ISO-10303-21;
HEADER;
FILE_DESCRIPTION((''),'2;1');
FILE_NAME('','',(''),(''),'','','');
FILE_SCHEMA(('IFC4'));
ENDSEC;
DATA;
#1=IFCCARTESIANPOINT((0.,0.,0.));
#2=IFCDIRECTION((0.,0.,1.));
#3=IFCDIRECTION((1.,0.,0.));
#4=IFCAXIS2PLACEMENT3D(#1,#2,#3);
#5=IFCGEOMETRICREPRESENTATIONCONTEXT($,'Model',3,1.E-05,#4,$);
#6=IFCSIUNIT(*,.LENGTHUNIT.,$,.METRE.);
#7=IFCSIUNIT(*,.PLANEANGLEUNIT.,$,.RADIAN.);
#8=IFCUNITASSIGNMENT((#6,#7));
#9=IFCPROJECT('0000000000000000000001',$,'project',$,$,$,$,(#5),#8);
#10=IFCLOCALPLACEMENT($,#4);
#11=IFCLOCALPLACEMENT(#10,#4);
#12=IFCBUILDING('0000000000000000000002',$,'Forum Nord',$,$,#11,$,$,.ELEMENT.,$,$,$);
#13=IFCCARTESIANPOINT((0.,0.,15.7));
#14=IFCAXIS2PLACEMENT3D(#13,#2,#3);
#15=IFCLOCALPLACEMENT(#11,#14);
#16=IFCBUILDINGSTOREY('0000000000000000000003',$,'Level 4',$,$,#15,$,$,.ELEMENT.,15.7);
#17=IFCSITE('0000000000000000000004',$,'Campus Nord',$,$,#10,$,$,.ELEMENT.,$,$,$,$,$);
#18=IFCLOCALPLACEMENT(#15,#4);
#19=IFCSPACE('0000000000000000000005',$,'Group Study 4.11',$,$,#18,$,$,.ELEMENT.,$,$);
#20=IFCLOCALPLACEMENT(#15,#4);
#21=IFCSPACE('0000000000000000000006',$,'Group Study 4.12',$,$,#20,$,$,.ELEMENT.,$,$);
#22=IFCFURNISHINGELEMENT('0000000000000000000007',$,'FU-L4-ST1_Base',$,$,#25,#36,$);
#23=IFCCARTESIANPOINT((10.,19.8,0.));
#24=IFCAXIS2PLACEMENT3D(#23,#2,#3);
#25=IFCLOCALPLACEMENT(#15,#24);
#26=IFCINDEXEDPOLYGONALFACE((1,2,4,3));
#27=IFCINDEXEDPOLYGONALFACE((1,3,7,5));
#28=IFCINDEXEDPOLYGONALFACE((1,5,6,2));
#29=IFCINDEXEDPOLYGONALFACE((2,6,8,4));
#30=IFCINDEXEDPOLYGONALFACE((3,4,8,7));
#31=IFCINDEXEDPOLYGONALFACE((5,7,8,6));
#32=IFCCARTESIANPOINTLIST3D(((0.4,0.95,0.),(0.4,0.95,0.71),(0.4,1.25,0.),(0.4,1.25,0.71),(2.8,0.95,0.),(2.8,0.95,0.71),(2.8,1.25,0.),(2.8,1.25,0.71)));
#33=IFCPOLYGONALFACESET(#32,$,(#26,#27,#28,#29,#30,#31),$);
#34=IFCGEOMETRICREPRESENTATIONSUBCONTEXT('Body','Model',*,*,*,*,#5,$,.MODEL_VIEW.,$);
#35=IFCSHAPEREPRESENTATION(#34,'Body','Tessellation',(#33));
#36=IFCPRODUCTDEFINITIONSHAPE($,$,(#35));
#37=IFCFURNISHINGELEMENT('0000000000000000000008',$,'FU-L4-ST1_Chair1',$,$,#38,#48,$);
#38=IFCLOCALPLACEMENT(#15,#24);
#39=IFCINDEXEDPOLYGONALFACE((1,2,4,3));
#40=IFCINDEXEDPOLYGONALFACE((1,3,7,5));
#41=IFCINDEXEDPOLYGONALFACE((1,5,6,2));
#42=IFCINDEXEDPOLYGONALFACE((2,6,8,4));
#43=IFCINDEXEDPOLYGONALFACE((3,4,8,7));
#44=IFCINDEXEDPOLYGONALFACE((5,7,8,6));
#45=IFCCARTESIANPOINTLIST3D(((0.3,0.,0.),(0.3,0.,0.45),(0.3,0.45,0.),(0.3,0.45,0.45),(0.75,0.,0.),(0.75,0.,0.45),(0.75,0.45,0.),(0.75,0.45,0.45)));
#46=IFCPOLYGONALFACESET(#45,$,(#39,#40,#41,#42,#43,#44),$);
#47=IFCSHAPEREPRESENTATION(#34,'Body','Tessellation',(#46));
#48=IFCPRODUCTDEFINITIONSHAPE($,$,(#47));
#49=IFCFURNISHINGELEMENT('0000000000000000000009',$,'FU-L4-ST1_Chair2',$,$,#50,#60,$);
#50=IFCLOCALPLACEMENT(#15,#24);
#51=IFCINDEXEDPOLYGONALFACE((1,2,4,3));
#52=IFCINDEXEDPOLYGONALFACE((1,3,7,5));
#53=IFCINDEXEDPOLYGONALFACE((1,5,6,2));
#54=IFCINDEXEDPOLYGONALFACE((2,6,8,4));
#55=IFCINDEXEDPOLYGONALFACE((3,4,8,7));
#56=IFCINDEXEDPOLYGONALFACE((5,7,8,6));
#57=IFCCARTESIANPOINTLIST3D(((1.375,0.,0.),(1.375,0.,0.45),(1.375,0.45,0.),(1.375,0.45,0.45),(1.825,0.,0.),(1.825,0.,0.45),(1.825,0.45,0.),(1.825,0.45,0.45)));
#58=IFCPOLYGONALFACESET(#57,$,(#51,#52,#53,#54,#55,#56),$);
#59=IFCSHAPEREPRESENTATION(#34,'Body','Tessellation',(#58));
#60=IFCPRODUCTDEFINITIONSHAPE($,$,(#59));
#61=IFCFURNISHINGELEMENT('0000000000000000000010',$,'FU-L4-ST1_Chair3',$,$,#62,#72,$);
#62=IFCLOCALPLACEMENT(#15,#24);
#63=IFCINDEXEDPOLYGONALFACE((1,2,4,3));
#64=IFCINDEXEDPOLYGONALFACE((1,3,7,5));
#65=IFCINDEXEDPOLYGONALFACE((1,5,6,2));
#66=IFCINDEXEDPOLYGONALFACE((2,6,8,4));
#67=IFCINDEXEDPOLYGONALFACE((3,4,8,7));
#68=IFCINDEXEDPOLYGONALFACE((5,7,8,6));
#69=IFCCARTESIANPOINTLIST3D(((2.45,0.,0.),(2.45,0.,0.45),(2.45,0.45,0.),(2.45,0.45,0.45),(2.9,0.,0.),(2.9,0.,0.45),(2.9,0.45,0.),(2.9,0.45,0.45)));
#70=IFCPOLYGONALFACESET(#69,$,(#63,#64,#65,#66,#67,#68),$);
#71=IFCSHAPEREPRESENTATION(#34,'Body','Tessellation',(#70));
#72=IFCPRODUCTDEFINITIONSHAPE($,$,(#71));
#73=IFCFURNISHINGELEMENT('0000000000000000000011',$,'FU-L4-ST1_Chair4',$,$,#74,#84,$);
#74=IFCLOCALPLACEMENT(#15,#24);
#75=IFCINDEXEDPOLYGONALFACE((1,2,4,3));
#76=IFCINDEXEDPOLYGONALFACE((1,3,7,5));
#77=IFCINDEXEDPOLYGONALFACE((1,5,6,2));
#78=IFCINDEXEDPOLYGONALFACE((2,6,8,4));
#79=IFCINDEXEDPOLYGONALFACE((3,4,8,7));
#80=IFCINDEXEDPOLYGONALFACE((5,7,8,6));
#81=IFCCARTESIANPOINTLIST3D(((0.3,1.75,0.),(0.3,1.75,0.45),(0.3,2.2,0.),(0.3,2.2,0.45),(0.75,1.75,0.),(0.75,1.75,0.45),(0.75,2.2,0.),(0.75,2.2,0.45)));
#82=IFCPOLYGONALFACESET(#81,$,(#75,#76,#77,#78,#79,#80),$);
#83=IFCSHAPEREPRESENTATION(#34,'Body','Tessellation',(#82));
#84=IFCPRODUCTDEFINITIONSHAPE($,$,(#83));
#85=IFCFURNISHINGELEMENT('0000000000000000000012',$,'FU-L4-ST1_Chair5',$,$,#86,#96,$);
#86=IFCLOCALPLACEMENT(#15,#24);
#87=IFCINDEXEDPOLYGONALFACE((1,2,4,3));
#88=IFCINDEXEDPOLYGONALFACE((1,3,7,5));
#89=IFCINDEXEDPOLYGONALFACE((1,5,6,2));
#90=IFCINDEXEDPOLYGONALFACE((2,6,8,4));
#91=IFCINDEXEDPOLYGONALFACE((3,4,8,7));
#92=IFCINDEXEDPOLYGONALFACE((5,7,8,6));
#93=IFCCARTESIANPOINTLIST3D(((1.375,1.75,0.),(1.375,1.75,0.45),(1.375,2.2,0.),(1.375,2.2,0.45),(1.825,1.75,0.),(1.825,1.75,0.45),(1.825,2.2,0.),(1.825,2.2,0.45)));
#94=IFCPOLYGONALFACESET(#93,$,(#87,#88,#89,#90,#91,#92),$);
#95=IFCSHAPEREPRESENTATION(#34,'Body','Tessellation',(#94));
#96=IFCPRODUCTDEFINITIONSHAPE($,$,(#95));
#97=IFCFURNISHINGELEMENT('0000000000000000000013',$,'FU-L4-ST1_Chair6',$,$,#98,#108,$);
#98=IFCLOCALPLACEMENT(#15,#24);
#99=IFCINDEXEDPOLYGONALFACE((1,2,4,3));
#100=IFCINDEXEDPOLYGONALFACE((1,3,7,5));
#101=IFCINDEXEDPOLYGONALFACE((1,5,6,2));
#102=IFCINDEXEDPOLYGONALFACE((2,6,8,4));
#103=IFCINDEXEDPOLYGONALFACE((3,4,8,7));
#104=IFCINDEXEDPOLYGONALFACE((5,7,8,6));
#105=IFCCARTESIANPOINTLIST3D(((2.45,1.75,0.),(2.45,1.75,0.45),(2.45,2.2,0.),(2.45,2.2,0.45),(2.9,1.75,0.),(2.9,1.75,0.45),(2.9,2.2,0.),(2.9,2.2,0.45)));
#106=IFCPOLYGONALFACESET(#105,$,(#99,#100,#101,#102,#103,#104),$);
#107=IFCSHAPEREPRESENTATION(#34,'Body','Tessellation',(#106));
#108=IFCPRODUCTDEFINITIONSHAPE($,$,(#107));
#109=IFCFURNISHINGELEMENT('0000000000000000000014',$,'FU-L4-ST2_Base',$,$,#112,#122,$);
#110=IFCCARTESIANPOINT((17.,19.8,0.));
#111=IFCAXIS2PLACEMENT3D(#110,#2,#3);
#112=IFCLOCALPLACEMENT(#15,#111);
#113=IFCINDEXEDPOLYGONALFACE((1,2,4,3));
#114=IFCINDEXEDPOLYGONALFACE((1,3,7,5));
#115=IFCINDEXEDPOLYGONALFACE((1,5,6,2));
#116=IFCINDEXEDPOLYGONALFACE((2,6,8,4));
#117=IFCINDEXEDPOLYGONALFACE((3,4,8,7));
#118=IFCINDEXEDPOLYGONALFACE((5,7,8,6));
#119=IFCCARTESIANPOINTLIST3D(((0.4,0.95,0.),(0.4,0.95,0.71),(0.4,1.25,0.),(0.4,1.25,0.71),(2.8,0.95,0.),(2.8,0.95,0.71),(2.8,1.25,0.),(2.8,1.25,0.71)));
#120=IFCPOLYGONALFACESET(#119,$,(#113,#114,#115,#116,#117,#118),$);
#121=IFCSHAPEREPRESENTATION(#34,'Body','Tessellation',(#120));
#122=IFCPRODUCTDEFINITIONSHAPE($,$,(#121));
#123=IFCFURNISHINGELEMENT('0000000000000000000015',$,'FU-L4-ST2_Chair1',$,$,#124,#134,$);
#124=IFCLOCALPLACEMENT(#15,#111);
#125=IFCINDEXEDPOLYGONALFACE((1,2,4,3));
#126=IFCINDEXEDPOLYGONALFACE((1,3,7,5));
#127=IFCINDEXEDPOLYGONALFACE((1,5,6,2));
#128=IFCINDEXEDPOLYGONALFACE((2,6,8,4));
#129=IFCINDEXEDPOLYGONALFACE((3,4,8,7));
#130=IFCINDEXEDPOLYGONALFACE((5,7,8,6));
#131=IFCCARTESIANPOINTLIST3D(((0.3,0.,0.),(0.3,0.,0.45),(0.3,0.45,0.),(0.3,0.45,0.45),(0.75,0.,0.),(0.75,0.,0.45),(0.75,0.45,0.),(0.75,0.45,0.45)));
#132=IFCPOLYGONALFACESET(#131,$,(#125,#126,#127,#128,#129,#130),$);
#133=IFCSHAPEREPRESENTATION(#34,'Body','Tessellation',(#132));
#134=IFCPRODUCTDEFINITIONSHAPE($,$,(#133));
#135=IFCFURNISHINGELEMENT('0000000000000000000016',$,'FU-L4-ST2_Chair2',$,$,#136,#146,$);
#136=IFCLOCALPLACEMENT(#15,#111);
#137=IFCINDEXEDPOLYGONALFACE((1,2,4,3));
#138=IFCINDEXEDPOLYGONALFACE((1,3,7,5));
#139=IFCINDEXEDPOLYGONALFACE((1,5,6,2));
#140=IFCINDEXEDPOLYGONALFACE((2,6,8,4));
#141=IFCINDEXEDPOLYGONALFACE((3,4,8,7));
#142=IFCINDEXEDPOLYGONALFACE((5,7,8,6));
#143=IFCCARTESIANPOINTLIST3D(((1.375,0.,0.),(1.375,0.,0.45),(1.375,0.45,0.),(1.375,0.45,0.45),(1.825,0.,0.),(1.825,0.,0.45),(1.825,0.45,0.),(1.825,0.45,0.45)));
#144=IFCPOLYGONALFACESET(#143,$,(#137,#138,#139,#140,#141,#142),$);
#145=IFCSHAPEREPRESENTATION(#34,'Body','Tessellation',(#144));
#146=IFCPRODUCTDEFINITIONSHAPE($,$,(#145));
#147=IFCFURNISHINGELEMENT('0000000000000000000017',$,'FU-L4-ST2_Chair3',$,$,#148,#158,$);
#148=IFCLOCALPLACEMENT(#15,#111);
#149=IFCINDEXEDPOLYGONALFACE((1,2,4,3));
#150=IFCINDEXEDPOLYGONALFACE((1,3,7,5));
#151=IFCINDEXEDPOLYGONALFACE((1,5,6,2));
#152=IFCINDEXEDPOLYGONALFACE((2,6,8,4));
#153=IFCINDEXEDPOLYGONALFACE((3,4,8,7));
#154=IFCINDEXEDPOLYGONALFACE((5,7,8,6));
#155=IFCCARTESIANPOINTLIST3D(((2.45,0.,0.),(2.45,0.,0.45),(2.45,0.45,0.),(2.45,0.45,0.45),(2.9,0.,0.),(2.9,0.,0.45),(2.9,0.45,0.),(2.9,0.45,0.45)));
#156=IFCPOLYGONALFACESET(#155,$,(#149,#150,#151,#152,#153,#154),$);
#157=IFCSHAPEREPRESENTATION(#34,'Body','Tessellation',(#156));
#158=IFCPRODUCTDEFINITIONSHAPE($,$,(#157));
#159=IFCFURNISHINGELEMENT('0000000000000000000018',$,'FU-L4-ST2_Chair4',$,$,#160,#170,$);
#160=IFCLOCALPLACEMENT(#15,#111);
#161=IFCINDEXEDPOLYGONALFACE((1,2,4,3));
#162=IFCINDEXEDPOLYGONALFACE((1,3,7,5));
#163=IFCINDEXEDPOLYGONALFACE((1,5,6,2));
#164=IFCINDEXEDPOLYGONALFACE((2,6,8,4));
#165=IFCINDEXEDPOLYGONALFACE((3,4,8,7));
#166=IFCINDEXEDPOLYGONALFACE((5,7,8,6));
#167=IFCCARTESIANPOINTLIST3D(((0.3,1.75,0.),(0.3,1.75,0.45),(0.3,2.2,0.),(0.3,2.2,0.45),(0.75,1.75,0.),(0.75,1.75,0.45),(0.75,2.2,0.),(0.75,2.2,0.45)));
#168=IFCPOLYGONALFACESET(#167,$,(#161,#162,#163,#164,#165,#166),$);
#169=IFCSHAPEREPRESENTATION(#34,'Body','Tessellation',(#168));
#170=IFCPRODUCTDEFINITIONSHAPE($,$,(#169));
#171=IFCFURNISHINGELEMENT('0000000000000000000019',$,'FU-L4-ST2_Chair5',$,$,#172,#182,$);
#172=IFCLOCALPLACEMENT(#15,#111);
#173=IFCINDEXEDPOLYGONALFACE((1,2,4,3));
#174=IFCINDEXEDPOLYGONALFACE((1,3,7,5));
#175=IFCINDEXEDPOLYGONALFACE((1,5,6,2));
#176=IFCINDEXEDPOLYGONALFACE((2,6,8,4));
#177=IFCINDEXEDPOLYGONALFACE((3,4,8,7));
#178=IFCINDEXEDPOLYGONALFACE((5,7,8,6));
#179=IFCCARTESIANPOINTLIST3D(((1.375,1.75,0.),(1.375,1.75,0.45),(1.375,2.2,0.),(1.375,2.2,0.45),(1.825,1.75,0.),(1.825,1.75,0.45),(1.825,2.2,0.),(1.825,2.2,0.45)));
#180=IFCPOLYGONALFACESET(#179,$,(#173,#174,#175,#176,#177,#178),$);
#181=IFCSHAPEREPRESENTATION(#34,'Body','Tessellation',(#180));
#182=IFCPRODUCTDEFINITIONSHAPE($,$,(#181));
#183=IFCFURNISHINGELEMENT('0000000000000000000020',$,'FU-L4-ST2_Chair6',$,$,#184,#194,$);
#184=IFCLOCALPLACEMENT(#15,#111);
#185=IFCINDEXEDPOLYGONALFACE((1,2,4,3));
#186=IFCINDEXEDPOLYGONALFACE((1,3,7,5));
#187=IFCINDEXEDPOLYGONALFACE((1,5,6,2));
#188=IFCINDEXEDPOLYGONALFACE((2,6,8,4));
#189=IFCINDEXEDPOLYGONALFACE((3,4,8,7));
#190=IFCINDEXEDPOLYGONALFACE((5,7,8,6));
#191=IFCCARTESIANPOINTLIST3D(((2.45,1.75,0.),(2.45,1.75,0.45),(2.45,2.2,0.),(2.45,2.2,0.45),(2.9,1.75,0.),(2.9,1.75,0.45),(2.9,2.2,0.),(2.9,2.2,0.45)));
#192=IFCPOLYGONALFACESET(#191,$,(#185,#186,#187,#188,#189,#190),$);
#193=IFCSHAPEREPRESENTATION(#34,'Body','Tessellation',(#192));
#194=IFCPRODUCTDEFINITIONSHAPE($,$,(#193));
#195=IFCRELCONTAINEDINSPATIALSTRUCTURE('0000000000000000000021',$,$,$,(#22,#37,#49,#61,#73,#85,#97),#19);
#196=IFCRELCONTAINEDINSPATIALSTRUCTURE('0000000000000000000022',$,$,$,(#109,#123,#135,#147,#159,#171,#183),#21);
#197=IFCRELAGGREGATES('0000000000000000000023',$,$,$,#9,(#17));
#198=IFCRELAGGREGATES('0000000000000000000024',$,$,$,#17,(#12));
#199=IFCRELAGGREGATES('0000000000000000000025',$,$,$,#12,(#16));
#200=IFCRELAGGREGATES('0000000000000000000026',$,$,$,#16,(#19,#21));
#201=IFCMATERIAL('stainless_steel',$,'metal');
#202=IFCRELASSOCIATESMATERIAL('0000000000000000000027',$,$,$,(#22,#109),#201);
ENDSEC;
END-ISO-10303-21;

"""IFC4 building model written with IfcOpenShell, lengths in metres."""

from ifc_helpers import new_model, si_unit, frame, frame_2d, origin_with_axes, place, context, subcontext, project, spatial, rectangle, extrude, material, element, save


model = new_model("IFC4")

# Units and contexts
model_context = context("Model", 3, precision=1e-05, world=origin_with_axes())
body_context = subcontext(model_context, "Body", "Model", "MODEL_VIEW")
ifc_project = project(units=[si_unit("LENGTHUNIT", "METRE"), si_unit("PLANEANGLEUNIT", "RADIAN")], contexts=[model_context])

# Site, building, storey
site_placement = place(None, origin_with_axes())
site = spatial("IfcSite", under=ifc_project, at=site_placement, Name="Campus Nord", CompositionType="ELEMENT")
building_placement = place(site_placement, origin_with_axes())
building = spatial("IfcBuilding", under=site, at=building_placement, Name="Forum Nord", CompositionType="ELEMENT")
storey_placement = place(building_placement, frame((0.0, 0.0, 15.7), z_axis=(0.0, 0.0, 1.0), x_axis=(1.0, 0.0, 0.0)))
storey = spatial("IfcBuildingStorey", under=building, at=storey_placement, Name="Level 4", CompositionType="ELEMENT", Elevation=15.7)

# Shared definitions
space_1_placement = place(storey_placement, origin_with_axes())
space_1 = spatial("IfcSpace", under=storey, at=space_1_placement, Name="Group Study 4.11", CompositionType="ELEMENT")

# Furnishing elements
ifc_material_1 = material(Name="stainless_steel", Category="metal")
furnishing_1_placement = place(storey_placement, frame((10.0, 19.8, 0.0), z_axis=(0.0, 0.0, 1.0), x_axis=(1.0, 0.0, 0.0)))
element("IfcFurnishingElement", 1, at=furnishing_1_placement, inside=space_1, material=ifc_material_1, Name="FU-L4-ST1_Base", context=body_context, shape_type="SweptSolid", body=[
    extrude(rectangle(XDim=2.4, YDim=0.3, at=frame_2d((1.6, 1.1), x_axis=(1.0, 0.0))), origin_with_axes(), (0.0, 0.0, 1.0), 0.71),
])
furnishing_2_placement = place(storey_placement, frame((10.0, 19.8, 0.0), z_axis=(0.0, 0.0, 1.0), x_axis=(1.0, 0.0, 0.0)))
element("IfcFurnishingElement", 2, at=furnishing_2_placement, inside=space_1, Name="FU-L4-ST1_Chair1", context=body_context, shape_type="SweptSolid", body=[
    extrude(rectangle(XDim=0.45, YDim=0.45, at=frame_2d((0.525, 0.225), x_axis=(1.0, 0.0))), origin_with_axes(), (0.0, 0.0, 1.0), 0.45),
])
furnishing_3_placement = place(storey_placement, frame((10.0, 19.8, 0.0), z_axis=(0.0, 0.0, 1.0), x_axis=(1.0, 0.0, 0.0)))
element("IfcFurnishingElement", 3, at=furnishing_3_placement, inside=space_1, Name="FU-L4-ST1_Chair2", context=body_context, shape_type="SweptSolid", body=[
    extrude(rectangle(XDim=0.45, YDim=0.45, at=frame_2d((1.6, 0.225), x_axis=(1.0, 0.0))), origin_with_axes(), (0.0, 0.0, 1.0), 0.45),
])
furnishing_4_placement = place(storey_placement, frame((10.0, 19.8, 0.0), z_axis=(0.0, 0.0, 1.0), x_axis=(1.0, 0.0, 0.0)))
element("IfcFurnishingElement", 4, at=furnishing_4_placement, inside=space_1, Name="FU-L4-ST1_Chair3", context=body_context, shape_type="SweptSolid", body=[
    extrude(rectangle(XDim=0.45, YDim=0.45, at=frame_2d((2.675, 0.225), x_axis=(1.0, 0.0))), origin_with_axes(), (0.0, 0.0, 1.0), 0.45),
])
furnishing_5_placement = place(storey_placement, frame((10.0, 19.8, 0.0), z_axis=(0.0, 0.0, 1.0), x_axis=(1.0, 0.0, 0.0)))
element("IfcFurnishingElement", 5, at=furnishing_5_placement, inside=space_1, Name="FU-L4-ST1_Chair4", context=body_context, shape_type="SweptSolid", body=[
    extrude(rectangle(XDim=0.45, YDim=0.45, at=frame_2d((0.525, 1.975), x_axis=(1.0, 0.0))), origin_with_axes(), (0.0, 0.0, 1.0), 0.45),
])
furnishing_6_placement = place(storey_placement, frame((10.0, 19.8, 0.0), z_axis=(0.0, 0.0, 1.0), x_axis=(1.0, 0.0, 0.0)))
element("IfcFurnishingElement", 6, at=furnishing_6_placement, inside=space_1, Name="FU-L4-ST1_Chair5", context=body_context, shape_type="SweptSolid", body=[
    extrude(rectangle(XDim=0.45, YDim=0.45, at=frame_2d((1.6, 1.975), x_axis=(1.0, 0.0))), origin_with_axes(), (0.0, 0.0, 1.0), 0.45),
])
furnishing_7_placement = place(storey_placement, frame((10.0, 19.8, 0.0), z_axis=(0.0, 0.0, 1.0), x_axis=(1.0, 0.0, 0.0)))
element("IfcFurnishingElement", 7, at=furnishing_7_placement, inside=space_1, Name="FU-L4-ST1_Chair6", context=body_context, shape_type="SweptSolid", body=[
    extrude(rectangle(XDim=0.45, YDim=0.45, at=frame_2d((2.675, 1.975), x_axis=(1.0, 0.0))), origin_with_axes(), (0.0, 0.0, 1.0), 0.45),
])

# Shared definitions
space_2_placement = place(storey_placement, origin_with_axes())
space_2 = spatial("IfcSpace", under=storey, at=space_2_placement, Name="Group Study 4.12", CompositionType="ELEMENT")

# Furnishing elements
furnishing_8_placement = place(storey_placement, frame((17.0, 19.8, 0.0), z_axis=(0.0, 0.0, 1.0), x_axis=(1.0, 0.0, 0.0)))
element("IfcFurnishingElement", 8, at=furnishing_8_placement, inside=space_2, material=ifc_material_1, Name="FU-L4-ST2_Base", context=body_context, shape_type="SweptSolid", body=[
    extrude(rectangle(XDim=2.4, YDim=0.3, at=frame_2d((1.6, 1.1), x_axis=(1.0, 0.0))), origin_with_axes(), (0.0, 0.0, 1.0), 0.71),
])
furnishing_9_placement = place(storey_placement, frame((17.0, 19.8, 0.0), z_axis=(0.0, 0.0, 1.0), x_axis=(1.0, 0.0, 0.0)))
element("IfcFurnishingElement", 9, at=furnishing_9_placement, inside=space_2, Name="FU-L4-ST2_Chair1", context=body_context, shape_type="SweptSolid", body=[
    extrude(rectangle(XDim=0.45, YDim=0.45, at=frame_2d((0.525, 0.225), x_axis=(1.0, 0.0))), origin_with_axes(), (0.0, 0.0, 1.0), 0.45),
])
furnishing_10_placement = place(storey_placement, frame((17.0, 19.8, 0.0), z_axis=(0.0, 0.0, 1.0), x_axis=(1.0, 0.0, 0.0)))
element("IfcFurnishingElement", 10, at=furnishing_10_placement, inside=space_2, Name="FU-L4-ST2_Chair2", context=body_context, shape_type="SweptSolid", body=[
    extrude(rectangle(XDim=0.45, YDim=0.45, at=frame_2d((1.6, 0.225), x_axis=(1.0, 0.0))), origin_with_axes(), (0.0, 0.0, 1.0), 0.45),
])
furnishing_11_placement = place(storey_placement, frame((17.0, 19.8, 0.0), z_axis=(0.0, 0.0, 1.0), x_axis=(1.0, 0.0, 0.0)))
element("IfcFurnishingElement", 11, at=furnishing_11_placement, inside=space_2, Name="FU-L4-ST2_Chair3", context=body_context, shape_type="SweptSolid", body=[
    extrude(rectangle(XDim=0.45, YDim=0.45, at=frame_2d((2.675, 0.225), x_axis=(1.0, 0.0))), origin_with_axes(), (0.0, 0.0, 1.0), 0.45),
])
furnishing_12_placement = place(storey_placement, frame((17.0, 19.8, 0.0), z_axis=(0.0, 0.0, 1.0), x_axis=(1.0, 0.0, 0.0)))
element("IfcFurnishingElement", 12, at=furnishing_12_placement, inside=space_2, Name="FU-L4-ST2_Chair4", context=body_context, shape_type="SweptSolid", body=[
    extrude(rectangle(XDim=0.45, YDim=0.45, at=frame_2d((0.525, 1.975), x_axis=(1.0, 0.0))), origin_with_axes(), (0.0, 0.0, 1.0), 0.45),
])
furnishing_13_placement = place(storey_placement, frame((17.0, 19.8, 0.0), z_axis=(0.0, 0.0, 1.0), x_axis=(1.0, 0.0, 0.0)))
element("IfcFurnishingElement", 13, at=furnishing_13_placement, inside=space_2, Name="FU-L4-ST2_Chair5", context=body_context, shape_type="SweptSolid", body=[
    extrude(rectangle(XDim=0.45, YDim=0.45, at=frame_2d((1.6, 1.975), x_axis=(1.0, 0.0))), origin_with_axes(), (0.0, 0.0, 1.0), 0.45),
])
furnishing_14_placement = place(storey_placement, frame((17.0, 19.8, 0.0), z_axis=(0.0, 0.0, 1.0), x_axis=(1.0, 0.0, 0.0)))
element("IfcFurnishingElement", 14, at=furnishing_14_placement, inside=space_2, Name="FU-L4-ST2_Chair6", context=body_context, shape_type="SweptSolid", body=[
    extrude(rectangle(XDim=0.45, YDim=0.45, at=frame_2d((2.675, 1.975), x_axis=(1.0, 0.0))), origin_with_axes(), (0.0, 0.0, 1.0), 0.45),
])

save(model, "model.ifc")
